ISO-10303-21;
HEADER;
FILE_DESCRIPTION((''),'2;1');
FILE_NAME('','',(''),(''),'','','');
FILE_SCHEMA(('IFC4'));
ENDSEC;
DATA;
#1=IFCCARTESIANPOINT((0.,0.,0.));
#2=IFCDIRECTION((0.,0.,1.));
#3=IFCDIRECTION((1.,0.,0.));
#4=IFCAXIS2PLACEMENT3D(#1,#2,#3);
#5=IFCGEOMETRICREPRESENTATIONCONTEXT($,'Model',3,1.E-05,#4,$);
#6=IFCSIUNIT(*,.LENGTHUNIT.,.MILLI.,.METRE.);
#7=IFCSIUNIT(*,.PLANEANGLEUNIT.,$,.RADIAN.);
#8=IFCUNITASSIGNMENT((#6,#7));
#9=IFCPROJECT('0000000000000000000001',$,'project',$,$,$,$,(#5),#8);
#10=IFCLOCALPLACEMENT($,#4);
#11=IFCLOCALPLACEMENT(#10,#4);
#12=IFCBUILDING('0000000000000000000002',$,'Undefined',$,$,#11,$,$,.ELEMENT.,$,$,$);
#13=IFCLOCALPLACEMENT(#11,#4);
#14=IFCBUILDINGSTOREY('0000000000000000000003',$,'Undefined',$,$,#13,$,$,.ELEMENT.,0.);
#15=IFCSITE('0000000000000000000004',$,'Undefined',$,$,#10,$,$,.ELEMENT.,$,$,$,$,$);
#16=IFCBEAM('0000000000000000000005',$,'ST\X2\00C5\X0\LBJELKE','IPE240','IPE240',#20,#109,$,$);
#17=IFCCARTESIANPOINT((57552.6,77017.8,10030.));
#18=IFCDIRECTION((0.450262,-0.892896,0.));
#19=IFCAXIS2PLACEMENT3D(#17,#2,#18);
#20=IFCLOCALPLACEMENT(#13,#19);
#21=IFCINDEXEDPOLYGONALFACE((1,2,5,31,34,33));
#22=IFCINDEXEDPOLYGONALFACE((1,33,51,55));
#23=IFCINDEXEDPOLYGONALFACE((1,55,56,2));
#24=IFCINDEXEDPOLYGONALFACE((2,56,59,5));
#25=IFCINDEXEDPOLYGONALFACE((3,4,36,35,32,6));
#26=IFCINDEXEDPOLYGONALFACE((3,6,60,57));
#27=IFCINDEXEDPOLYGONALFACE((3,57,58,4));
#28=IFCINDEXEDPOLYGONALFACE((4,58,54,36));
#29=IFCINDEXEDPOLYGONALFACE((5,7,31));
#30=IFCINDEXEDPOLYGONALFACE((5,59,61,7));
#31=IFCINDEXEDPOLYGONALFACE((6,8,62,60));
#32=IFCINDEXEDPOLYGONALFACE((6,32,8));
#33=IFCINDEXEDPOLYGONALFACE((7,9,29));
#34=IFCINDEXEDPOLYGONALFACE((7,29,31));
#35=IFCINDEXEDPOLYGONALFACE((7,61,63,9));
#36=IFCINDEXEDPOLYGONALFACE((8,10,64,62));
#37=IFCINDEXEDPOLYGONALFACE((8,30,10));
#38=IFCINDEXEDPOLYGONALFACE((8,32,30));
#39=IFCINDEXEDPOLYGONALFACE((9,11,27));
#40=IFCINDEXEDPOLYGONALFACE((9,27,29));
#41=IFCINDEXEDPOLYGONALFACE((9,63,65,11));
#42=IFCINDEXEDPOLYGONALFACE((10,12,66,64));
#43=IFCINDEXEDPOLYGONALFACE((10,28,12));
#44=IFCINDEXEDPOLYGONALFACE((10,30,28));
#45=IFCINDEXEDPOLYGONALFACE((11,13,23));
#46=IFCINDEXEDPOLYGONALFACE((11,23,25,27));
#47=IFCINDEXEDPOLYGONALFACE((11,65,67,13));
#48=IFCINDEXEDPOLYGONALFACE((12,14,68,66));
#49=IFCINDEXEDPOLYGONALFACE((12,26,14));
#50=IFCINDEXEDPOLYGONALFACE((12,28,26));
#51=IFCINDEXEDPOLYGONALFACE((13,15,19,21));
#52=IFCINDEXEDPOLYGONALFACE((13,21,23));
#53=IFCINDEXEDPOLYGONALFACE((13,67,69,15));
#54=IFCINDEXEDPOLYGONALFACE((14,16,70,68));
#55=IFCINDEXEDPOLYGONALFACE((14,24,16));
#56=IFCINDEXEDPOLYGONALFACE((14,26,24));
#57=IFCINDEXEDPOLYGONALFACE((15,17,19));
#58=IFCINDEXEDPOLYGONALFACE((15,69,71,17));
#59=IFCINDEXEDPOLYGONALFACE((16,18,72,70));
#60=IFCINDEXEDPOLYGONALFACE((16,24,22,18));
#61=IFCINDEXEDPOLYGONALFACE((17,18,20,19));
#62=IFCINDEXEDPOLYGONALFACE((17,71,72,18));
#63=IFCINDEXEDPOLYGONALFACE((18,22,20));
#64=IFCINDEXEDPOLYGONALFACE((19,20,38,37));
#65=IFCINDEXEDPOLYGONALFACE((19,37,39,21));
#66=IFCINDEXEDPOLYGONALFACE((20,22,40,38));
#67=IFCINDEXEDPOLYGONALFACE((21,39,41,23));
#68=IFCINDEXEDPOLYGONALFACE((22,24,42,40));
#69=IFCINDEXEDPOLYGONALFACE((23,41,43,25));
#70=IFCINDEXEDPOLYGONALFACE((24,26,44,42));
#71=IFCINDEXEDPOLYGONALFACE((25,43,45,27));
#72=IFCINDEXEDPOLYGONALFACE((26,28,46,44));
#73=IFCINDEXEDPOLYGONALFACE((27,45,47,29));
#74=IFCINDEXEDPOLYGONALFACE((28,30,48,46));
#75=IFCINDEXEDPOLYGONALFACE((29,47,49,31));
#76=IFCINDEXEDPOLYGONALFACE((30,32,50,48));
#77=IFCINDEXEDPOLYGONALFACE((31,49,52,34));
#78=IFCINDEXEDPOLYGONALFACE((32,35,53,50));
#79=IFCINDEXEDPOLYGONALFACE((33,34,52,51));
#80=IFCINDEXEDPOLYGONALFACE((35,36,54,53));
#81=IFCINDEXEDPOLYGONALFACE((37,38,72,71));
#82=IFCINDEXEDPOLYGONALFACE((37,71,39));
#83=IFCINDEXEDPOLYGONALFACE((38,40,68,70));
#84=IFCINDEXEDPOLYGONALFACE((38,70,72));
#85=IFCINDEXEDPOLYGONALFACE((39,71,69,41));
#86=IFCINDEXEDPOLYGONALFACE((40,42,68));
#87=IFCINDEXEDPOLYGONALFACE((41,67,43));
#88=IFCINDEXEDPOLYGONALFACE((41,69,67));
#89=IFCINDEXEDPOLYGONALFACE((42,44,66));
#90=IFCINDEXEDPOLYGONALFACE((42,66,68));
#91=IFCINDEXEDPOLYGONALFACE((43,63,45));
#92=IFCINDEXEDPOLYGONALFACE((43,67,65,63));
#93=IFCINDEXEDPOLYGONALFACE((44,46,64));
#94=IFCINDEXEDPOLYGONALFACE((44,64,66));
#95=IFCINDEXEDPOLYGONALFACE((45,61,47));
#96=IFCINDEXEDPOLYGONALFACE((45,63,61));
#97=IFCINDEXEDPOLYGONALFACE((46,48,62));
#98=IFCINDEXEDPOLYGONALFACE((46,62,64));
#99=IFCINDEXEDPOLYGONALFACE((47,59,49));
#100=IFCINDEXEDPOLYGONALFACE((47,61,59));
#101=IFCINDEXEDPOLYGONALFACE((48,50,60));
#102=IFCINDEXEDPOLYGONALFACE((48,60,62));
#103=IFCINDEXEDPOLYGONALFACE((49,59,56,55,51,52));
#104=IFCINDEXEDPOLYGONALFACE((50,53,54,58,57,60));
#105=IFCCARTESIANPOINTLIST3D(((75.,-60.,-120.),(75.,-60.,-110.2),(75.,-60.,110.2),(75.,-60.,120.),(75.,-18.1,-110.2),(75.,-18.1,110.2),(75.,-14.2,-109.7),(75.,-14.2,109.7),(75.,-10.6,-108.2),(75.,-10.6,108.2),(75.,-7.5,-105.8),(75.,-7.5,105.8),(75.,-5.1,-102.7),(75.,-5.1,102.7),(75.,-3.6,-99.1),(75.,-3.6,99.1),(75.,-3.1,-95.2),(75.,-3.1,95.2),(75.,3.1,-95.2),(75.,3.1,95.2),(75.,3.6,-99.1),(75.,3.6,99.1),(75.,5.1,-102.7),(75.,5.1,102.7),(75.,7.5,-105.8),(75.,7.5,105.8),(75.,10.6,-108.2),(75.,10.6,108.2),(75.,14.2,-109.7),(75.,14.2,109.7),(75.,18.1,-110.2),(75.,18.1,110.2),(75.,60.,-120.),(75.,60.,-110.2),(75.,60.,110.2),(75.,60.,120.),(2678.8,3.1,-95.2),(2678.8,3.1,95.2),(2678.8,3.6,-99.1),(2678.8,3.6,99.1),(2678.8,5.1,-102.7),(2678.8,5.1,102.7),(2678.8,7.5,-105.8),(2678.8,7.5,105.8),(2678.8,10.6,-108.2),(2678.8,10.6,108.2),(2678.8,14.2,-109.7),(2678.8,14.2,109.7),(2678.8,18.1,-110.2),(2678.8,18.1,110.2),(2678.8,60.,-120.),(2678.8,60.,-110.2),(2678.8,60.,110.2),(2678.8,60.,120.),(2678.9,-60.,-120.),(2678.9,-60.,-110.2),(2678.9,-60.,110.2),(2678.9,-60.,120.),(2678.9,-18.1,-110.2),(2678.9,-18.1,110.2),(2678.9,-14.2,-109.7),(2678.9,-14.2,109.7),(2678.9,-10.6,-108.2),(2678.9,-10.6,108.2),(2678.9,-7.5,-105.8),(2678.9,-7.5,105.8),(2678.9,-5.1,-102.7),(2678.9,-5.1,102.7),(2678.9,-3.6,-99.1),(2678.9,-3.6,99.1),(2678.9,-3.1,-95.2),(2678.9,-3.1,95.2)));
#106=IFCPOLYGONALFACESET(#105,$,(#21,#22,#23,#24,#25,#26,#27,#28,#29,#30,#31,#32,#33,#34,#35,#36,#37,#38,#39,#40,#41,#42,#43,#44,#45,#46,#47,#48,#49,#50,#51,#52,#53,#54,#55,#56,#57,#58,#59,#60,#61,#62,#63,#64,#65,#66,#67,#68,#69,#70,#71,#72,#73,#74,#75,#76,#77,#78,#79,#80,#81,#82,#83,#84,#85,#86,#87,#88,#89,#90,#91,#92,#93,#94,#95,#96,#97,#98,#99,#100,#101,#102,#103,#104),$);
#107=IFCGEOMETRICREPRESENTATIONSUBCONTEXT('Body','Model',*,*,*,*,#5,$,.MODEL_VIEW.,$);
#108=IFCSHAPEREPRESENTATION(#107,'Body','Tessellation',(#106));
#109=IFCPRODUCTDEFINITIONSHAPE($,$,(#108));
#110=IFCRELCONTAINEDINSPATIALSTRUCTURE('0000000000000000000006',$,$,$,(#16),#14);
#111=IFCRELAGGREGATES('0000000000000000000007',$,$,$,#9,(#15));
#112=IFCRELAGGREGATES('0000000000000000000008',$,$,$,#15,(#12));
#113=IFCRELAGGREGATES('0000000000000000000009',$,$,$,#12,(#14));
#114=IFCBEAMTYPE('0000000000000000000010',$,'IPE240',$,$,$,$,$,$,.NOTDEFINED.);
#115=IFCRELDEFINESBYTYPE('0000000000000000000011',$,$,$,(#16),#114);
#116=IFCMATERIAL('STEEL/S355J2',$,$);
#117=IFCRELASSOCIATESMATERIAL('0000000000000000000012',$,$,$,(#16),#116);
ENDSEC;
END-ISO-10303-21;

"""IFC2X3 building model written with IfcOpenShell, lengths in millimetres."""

from ifc_helpers import new_model, si_unit, frame, origin_with_axes, origin_2d_with_axis, place, context, subcontext, project, spatial, i_section, extrude, clip, halfspace, material, type_object, element, save


model = new_model("IFC2X3")

# Units and contexts
model_context = context("Model", 3, precision=1e-05, world=origin_with_axes())
body_context = subcontext(model_context, "Body", "Model", "MODEL_VIEW")
ifc_project = project(units=[si_unit("LENGTHUNIT", "METRE", prefix="MILLI"), si_unit("PLANEANGLEUNIT", "RADIAN")], contexts=[model_context])

# Site, building, storey
site_placement = place(None, origin_with_axes())
site = spatial("IfcSite", under=ifc_project, at=site_placement, Name="Undefined", CompositionType="ELEMENT")
building_placement = place(site_placement, origin_with_axes())
building = spatial("IfcBuilding", under=site, at=building_placement, Name="Undefined", CompositionType="ELEMENT")
storey_placement = place(building_placement, origin_with_axes())
storey = spatial("IfcBuildingStorey", under=building, at=storey_placement, Name="Undefined", CompositionType="ELEMENT", Elevation=0.0)

# Shared definitions
ifc_material_1 = material(Name="STEEL/S355J2")

# Beam
beam_type_1 = type_object("IfcBeamType", Name="IPE240", PredefinedType="NOTDEFINED")
beam_1_placement = place(storey_placement, frame((57552.6, 77017.8, 10030.0), z_axis=(0.0, 0.0, 1.0), x_axis=(0.450262, -0.892896, 0.0)))
element("IfcBeam", 1, at=beam_1_placement, inside=storey, type_object=beam_type_1, material=ifc_material_1, Name="STÅLBJELKE", Description="IPE240", ObjectType="IPE240", context=body_context, shape_type="Clipping", body=[
    clip(clip(extrude(i_section(OverallWidth=120.0, OverallDepth=240.0, WebThickness=6.2, FlangeThickness=9.8, FilletRadius=15.0, at=origin_2d_with_axis()), frame((2776.3, 0.0, 0.0), z_axis=(-1.0, 0.0, 0.0), x_axis=(0.0, -1.0, 0.0)), (0.0, 0.0, 1.0), 2798.8), halfspace(frame((2678.8, 0.4, 220.0), z_axis=(-1.0, -0.00028, 0.0), x_axis=(0.00028, -1.0, 0.0)), True)), halfspace(frame((75.0, 0.9, 220.0), z_axis=(1.0, 0.00028, 0.0), x_axis=(-0.00028, 1.0, 0.0)), True)),
])

save(model, "model.ifc")
